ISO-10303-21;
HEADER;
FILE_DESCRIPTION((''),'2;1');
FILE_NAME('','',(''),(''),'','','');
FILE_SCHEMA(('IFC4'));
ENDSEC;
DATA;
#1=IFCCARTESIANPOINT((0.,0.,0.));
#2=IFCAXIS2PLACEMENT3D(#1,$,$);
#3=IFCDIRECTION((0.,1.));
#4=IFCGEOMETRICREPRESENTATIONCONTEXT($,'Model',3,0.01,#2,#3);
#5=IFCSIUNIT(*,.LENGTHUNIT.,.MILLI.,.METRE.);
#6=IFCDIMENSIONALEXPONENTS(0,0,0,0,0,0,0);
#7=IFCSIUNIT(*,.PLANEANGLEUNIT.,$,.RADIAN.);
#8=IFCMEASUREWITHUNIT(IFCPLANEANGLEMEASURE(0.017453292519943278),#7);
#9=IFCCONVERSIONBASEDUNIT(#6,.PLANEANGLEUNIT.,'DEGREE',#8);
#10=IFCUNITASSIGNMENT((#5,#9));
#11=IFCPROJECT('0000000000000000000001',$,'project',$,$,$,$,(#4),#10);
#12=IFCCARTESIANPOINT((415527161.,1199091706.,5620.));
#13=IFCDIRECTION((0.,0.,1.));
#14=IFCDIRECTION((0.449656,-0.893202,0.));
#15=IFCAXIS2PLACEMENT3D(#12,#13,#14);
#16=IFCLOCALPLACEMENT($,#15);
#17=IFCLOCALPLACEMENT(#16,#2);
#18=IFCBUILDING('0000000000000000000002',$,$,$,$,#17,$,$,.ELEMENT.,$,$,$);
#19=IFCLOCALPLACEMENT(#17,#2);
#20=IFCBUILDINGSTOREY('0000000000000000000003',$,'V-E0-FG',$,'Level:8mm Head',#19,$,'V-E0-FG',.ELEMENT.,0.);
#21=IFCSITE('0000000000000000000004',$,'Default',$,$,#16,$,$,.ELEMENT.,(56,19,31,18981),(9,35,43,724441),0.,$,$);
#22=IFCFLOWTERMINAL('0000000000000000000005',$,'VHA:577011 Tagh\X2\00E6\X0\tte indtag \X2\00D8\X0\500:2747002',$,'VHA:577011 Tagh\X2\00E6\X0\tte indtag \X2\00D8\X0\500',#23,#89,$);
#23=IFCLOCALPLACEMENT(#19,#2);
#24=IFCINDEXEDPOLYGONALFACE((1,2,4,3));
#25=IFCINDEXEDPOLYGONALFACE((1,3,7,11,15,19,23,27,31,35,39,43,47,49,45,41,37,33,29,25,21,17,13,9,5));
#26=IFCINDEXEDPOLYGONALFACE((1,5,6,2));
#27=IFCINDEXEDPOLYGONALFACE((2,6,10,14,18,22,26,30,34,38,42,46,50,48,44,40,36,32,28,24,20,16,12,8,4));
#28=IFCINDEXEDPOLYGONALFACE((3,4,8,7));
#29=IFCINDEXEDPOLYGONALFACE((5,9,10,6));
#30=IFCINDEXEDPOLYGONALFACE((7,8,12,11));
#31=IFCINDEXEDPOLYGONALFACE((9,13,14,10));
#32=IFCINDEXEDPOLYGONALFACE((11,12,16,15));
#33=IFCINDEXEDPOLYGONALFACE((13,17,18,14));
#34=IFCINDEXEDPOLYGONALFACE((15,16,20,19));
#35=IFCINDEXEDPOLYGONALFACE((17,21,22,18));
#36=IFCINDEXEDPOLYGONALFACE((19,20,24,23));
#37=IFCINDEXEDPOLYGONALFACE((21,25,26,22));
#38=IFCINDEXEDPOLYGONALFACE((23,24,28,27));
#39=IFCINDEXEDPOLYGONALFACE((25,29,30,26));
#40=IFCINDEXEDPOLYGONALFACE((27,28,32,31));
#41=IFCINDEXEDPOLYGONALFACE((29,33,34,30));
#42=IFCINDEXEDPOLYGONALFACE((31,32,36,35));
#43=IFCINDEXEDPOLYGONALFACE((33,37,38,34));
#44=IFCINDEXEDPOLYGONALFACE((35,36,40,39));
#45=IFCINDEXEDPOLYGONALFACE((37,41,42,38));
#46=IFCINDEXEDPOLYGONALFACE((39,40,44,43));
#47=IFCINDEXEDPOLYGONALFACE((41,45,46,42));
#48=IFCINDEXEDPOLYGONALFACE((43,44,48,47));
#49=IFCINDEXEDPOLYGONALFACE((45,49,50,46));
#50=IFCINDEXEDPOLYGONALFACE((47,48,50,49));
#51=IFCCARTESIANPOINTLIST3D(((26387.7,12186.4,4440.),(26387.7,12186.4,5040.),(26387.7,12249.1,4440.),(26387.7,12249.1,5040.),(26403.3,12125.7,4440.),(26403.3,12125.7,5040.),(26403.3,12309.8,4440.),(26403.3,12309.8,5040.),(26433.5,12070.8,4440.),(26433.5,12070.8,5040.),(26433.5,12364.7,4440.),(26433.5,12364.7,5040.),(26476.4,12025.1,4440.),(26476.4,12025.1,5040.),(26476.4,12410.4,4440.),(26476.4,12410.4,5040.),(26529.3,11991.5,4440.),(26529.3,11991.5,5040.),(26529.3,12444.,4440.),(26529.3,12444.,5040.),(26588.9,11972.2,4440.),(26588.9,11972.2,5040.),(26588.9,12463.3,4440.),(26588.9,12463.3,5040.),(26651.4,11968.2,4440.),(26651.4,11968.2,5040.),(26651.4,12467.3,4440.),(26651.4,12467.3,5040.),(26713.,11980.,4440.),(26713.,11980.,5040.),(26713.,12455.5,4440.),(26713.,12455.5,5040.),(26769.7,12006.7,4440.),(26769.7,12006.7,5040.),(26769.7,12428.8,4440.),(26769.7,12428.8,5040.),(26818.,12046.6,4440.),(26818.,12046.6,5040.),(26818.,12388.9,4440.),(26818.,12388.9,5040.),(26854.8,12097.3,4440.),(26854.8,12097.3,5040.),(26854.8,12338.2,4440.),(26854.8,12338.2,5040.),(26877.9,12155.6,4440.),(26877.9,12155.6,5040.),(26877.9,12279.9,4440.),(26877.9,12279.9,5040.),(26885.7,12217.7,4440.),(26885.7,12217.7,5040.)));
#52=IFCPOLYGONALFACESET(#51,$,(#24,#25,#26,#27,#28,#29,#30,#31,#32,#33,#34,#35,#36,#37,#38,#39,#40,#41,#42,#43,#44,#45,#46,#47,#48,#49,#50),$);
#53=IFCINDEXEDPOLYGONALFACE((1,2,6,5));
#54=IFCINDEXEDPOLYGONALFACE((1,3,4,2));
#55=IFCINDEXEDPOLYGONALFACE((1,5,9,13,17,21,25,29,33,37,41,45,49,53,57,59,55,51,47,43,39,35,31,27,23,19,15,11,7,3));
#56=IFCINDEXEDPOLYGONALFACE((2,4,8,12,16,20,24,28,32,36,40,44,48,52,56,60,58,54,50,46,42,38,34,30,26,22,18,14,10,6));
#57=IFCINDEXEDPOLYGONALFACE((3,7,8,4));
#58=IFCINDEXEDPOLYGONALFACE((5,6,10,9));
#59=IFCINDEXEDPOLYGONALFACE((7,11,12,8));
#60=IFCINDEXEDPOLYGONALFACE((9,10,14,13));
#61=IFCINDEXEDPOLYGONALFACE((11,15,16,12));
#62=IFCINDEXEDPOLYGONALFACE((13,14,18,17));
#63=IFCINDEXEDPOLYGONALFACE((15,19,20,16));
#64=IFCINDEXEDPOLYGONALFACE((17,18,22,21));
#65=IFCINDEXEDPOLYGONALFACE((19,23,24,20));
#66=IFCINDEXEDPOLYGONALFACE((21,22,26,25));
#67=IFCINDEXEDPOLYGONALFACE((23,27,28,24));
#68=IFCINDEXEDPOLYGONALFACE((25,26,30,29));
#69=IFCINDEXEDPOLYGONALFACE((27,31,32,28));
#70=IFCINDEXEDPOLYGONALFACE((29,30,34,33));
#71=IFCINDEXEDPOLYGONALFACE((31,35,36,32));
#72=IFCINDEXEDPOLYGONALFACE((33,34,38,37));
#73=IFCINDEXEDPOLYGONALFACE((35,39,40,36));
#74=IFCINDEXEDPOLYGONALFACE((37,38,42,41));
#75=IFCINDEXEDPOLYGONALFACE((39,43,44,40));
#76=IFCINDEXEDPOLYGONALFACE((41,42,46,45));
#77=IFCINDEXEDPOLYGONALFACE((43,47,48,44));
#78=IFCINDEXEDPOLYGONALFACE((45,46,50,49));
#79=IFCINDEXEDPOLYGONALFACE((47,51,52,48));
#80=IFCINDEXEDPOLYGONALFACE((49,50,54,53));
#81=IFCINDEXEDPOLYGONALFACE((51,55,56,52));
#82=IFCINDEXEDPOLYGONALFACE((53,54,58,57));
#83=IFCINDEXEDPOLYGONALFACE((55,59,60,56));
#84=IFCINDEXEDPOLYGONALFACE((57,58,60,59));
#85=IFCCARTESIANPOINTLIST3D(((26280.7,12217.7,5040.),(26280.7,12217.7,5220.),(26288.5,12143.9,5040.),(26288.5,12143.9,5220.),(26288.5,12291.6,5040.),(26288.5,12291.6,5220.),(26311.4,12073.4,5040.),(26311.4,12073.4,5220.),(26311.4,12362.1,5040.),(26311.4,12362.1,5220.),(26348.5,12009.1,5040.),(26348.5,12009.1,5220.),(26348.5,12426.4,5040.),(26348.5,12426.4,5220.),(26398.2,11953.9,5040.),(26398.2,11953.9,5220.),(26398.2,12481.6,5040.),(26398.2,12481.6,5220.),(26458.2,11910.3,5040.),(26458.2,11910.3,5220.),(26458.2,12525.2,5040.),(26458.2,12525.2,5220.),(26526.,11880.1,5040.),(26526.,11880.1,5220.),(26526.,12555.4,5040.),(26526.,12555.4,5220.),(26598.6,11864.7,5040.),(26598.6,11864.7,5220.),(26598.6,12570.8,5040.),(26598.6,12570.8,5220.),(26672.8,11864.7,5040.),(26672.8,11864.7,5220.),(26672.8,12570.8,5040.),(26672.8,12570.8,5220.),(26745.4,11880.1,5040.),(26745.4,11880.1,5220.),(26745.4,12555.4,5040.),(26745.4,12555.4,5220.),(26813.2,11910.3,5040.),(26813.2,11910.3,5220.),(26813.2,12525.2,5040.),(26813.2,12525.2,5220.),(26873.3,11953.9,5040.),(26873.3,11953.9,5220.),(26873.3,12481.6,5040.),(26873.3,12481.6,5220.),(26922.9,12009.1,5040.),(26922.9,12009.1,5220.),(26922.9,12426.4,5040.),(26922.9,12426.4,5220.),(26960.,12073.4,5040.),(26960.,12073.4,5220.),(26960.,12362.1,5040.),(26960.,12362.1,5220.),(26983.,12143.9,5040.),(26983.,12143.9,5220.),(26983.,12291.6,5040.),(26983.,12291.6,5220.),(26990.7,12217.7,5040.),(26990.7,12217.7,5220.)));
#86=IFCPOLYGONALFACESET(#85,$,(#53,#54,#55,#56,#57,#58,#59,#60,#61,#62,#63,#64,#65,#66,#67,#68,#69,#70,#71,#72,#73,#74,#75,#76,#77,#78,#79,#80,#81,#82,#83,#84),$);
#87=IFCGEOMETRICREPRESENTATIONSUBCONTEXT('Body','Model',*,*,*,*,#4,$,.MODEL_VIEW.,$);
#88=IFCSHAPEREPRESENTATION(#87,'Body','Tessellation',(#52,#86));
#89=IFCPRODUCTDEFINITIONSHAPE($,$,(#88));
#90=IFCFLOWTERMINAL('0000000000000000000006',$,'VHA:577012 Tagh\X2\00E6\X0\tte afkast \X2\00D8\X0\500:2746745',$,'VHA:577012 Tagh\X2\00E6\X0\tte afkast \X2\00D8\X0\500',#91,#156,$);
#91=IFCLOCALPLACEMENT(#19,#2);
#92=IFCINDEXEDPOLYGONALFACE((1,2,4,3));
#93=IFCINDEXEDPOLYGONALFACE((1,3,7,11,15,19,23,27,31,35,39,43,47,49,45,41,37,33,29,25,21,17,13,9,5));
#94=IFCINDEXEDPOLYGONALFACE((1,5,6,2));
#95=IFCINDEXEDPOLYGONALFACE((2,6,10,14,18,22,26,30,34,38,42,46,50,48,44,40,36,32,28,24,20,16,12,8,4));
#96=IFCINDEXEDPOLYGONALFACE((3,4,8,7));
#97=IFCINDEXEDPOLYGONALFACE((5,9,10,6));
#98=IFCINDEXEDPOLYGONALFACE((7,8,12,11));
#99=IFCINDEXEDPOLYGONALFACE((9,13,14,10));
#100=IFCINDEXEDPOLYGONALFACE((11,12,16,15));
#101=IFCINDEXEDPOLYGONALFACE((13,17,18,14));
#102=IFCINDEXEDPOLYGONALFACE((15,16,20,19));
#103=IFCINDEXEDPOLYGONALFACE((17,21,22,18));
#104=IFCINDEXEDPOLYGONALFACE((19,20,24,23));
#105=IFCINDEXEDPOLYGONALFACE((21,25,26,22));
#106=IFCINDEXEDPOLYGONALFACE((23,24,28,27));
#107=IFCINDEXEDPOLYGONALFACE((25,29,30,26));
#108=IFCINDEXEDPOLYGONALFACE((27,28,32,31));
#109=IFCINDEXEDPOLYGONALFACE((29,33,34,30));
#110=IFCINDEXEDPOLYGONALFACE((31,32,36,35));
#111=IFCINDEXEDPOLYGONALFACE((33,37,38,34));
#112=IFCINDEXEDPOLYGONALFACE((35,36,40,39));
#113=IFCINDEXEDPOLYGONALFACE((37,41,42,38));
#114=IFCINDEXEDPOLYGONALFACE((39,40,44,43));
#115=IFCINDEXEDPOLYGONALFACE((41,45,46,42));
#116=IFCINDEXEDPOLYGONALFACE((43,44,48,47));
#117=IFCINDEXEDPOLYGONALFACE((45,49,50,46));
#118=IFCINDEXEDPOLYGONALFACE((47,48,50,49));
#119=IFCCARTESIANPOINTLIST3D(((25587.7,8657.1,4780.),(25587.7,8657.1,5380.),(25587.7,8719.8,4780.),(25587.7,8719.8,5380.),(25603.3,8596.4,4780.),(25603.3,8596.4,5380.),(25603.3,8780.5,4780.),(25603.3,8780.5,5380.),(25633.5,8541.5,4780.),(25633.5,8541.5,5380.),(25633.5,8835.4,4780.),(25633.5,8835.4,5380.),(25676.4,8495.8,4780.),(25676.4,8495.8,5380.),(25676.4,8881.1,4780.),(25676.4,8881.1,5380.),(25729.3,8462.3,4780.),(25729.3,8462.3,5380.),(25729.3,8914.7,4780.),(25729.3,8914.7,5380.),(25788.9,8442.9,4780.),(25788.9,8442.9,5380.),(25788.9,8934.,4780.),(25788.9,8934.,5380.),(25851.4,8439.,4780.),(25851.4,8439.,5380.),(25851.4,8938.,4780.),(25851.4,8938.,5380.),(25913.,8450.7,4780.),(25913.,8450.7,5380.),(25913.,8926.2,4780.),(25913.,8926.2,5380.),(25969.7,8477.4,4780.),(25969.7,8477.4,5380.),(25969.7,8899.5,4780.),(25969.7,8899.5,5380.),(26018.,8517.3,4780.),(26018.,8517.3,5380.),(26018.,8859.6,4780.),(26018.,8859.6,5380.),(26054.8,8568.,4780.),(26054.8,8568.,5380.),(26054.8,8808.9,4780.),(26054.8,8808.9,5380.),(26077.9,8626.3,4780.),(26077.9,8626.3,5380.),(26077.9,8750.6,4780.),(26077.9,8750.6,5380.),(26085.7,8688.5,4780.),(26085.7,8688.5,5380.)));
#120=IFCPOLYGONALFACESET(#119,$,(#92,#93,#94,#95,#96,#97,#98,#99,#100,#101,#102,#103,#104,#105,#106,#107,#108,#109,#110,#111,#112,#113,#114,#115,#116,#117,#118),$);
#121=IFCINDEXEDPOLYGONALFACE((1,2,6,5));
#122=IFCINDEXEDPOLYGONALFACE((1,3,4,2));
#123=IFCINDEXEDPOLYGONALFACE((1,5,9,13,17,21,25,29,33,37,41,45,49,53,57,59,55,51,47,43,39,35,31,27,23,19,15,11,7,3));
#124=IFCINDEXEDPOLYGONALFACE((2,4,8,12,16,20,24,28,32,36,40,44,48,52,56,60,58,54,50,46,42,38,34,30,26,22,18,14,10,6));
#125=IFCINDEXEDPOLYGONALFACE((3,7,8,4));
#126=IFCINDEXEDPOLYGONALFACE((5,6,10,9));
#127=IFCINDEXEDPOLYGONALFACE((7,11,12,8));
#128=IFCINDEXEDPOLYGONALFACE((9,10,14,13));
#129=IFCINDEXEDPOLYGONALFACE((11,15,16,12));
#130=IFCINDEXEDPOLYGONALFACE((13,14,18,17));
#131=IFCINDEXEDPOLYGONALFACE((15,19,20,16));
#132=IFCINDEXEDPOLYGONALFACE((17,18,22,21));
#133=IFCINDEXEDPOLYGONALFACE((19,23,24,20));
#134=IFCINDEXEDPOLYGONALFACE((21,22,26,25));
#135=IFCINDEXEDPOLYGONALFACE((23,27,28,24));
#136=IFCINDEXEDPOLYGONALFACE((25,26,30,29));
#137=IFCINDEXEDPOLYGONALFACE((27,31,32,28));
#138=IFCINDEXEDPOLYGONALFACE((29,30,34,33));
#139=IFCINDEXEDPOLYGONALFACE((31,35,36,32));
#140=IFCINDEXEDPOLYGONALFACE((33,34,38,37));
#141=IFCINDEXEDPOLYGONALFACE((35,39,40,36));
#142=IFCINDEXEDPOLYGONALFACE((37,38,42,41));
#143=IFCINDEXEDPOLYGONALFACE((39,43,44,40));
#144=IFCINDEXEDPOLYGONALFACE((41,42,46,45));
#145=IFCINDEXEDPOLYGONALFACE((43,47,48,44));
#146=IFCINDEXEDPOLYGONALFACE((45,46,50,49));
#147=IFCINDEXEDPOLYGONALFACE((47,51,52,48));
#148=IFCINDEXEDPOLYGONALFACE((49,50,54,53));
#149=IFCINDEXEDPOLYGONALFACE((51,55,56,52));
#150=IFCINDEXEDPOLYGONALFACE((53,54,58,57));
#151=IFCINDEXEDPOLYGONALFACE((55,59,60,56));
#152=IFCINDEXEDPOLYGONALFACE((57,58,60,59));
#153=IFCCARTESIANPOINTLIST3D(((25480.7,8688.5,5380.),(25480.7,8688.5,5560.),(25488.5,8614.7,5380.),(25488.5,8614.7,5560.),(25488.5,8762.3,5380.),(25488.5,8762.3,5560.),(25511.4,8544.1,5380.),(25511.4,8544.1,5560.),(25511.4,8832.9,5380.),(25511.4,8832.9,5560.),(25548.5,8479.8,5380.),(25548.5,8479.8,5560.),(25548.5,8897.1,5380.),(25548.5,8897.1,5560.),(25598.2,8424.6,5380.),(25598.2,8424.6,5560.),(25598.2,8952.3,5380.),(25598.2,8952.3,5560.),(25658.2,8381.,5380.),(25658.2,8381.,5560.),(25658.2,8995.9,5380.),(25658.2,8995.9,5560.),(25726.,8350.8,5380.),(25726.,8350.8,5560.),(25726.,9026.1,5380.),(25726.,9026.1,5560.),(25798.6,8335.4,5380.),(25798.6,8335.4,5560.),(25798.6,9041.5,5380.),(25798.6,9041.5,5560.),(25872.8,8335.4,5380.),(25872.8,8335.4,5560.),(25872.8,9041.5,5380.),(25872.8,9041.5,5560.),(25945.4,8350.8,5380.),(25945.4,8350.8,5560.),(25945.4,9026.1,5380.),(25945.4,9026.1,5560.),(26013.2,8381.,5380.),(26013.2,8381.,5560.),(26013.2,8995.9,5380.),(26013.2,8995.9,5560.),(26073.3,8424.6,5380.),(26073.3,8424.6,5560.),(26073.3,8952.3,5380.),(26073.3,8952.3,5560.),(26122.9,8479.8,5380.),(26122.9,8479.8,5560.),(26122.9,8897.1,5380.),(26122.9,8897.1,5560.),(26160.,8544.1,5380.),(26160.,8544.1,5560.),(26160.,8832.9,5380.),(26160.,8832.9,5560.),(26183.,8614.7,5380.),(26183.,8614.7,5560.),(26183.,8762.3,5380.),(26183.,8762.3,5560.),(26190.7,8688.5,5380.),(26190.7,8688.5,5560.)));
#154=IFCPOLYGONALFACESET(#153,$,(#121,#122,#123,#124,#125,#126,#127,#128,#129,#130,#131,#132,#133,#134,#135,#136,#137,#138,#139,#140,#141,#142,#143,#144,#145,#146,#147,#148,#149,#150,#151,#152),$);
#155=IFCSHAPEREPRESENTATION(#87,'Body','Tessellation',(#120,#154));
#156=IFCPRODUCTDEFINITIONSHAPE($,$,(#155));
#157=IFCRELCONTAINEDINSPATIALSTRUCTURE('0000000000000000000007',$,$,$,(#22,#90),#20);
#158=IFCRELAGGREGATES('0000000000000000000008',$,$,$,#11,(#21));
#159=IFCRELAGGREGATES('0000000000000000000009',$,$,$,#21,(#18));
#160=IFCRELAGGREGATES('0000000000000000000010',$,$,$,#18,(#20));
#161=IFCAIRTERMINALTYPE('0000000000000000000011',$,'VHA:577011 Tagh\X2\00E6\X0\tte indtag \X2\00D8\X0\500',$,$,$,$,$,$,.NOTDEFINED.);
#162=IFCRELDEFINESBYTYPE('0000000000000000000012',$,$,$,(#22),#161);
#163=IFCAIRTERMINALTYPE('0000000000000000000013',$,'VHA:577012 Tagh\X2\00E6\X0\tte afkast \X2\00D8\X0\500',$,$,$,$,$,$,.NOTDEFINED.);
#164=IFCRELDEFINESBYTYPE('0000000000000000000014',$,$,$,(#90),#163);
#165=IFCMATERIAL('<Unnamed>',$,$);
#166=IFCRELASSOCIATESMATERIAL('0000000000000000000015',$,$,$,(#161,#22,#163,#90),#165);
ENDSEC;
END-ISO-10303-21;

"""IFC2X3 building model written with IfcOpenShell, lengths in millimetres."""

from ifc_helpers import new_model, entity, si_unit, converted_unit, direction, frame, frame_2d, origin, place, context, subcontext, project, spatial, circle, extrude, source, transform, mapped, material, type_object, type_shapes, element, save


model = new_model("IFC2X3")

# Units and contexts
model_context = context("Model", 3, precision=0.01, world=origin(), true_north=direction((0.0, 1.0)))
body_context = subcontext(model_context, "Body", "Model", "MODEL_VIEW")
ifc_project = project(units=[si_unit("LENGTHUNIT", "METRE", prefix="MILLI"), converted_unit("PLANEANGLEUNIT", "DEGREE", entity("IfcPlaneAngleMeasure", 0.017453292519943278), si_unit("PLANEANGLEUNIT", "RADIAN"), dimensions=[0, 0, 0, 0, 0, 0, 0])], contexts=[model_context])

# Site, building, storey
site_placement = place(None, frame((415527161.0, 1199091706.0, 5620.0), z_axis=(0.0, 0.0, 1.0), x_axis=(0.449656, -0.893202, 0.0)))
site = spatial("IfcSite", under=ifc_project, at=site_placement, Name="Default", CompositionType="ELEMENT", RefLatitude=(56, 19, 31, 18981), RefLongitude=(9, 35, 43, 724441), RefElevation=0.0)
building_placement = place(site_placement, origin())
building = spatial("IfcBuilding", under=site, at=building_placement, CompositionType="ELEMENT")
storey_placement = place(building_placement, origin())
storey = spatial("IfcBuildingStorey", under=building, at=storey_placement, Name="V-E0-FG", ObjectType="Level:8mm Head", LongName="V-E0-FG", CompositionType="ELEMENT", Elevation=0.0)

# Flow terminals
ifc_material = material(Name="<Unnamed>")
air_terminal_type_1 = type_object("IfcAirTerminalType", Name="VHA:577011 Taghætte indtag Ø500", PredefinedType="NOTDEFINED", material=ifc_material)
shared_shape_1 = source(origin(), body_context, "Body", "SweptSolid", [
    extrude(circle(Radius=250.0, at=frame_2d((0.0, 0.0), x_axis=(1.0, 0.0))), origin(), (0.0, 0.0, 1.0), 600.0),
    extrude(circle(Radius=355.0, at=frame_2d((0.0, 0.0), x_axis=(1.0, 0.0))), frame((0.0, 0.0, 600.0)), (0.0, 0.0, 1.0), 180.0),
])
type_shapes(air_terminal_type_1, [shared_shape_1])
flow_terminal_1_placement = place(storey_placement, frame((26635.7, 12217.7, 4440.0)))
element("IfcFlowTerminal", 1, at=flow_terminal_1_placement, inside=storey, type_object=air_terminal_type_1, material=ifc_material, Name="VHA:577011 Taghætte indtag Ø500:2747002", ObjectType="VHA:577011 Taghætte indtag Ø500", context=body_context, shape_type="MappedRepresentation", body=[
    mapped(shared_shape_1, transform((0.0, 0.0, 0.0), scale=1.0)),
])
air_terminal_type_2 = type_object("IfcAirTerminalType", Name="VHA:577012 Taghætte afkast Ø500", PredefinedType="NOTDEFINED", material=ifc_material)
shared_shape_2 = source(origin(), body_context, "Body", "SweptSolid", [
    extrude(circle(Radius=250.0, at=frame_2d((0.0, 0.0), x_axis=(1.0, 0.0))), origin(), (0.0, 0.0, 1.0), 600.0),
    extrude(circle(Radius=355.0, at=frame_2d((0.0, 0.0), x_axis=(1.0, 0.0))), frame((0.0, 0.0, 600.0)), (0.0, 0.0, 1.0), 180.0),
])
type_shapes(air_terminal_type_2, [shared_shape_2])
flow_terminal_2_placement = place(storey_placement, frame((25835.7, 8688.5, 4780.0)))
element("IfcFlowTerminal", 2, at=flow_terminal_2_placement, inside=storey, type_object=air_terminal_type_2, material=ifc_material, Name="VHA:577012 Taghætte afkast Ø500:2746745", ObjectType="VHA:577012 Taghætte afkast Ø500", context=body_context, shape_type="MappedRepresentation", body=[
    mapped(shared_shape_2, transform((0.0, 0.0, 0.0), scale=1.0)),
])

save(model, "model.ifc")
